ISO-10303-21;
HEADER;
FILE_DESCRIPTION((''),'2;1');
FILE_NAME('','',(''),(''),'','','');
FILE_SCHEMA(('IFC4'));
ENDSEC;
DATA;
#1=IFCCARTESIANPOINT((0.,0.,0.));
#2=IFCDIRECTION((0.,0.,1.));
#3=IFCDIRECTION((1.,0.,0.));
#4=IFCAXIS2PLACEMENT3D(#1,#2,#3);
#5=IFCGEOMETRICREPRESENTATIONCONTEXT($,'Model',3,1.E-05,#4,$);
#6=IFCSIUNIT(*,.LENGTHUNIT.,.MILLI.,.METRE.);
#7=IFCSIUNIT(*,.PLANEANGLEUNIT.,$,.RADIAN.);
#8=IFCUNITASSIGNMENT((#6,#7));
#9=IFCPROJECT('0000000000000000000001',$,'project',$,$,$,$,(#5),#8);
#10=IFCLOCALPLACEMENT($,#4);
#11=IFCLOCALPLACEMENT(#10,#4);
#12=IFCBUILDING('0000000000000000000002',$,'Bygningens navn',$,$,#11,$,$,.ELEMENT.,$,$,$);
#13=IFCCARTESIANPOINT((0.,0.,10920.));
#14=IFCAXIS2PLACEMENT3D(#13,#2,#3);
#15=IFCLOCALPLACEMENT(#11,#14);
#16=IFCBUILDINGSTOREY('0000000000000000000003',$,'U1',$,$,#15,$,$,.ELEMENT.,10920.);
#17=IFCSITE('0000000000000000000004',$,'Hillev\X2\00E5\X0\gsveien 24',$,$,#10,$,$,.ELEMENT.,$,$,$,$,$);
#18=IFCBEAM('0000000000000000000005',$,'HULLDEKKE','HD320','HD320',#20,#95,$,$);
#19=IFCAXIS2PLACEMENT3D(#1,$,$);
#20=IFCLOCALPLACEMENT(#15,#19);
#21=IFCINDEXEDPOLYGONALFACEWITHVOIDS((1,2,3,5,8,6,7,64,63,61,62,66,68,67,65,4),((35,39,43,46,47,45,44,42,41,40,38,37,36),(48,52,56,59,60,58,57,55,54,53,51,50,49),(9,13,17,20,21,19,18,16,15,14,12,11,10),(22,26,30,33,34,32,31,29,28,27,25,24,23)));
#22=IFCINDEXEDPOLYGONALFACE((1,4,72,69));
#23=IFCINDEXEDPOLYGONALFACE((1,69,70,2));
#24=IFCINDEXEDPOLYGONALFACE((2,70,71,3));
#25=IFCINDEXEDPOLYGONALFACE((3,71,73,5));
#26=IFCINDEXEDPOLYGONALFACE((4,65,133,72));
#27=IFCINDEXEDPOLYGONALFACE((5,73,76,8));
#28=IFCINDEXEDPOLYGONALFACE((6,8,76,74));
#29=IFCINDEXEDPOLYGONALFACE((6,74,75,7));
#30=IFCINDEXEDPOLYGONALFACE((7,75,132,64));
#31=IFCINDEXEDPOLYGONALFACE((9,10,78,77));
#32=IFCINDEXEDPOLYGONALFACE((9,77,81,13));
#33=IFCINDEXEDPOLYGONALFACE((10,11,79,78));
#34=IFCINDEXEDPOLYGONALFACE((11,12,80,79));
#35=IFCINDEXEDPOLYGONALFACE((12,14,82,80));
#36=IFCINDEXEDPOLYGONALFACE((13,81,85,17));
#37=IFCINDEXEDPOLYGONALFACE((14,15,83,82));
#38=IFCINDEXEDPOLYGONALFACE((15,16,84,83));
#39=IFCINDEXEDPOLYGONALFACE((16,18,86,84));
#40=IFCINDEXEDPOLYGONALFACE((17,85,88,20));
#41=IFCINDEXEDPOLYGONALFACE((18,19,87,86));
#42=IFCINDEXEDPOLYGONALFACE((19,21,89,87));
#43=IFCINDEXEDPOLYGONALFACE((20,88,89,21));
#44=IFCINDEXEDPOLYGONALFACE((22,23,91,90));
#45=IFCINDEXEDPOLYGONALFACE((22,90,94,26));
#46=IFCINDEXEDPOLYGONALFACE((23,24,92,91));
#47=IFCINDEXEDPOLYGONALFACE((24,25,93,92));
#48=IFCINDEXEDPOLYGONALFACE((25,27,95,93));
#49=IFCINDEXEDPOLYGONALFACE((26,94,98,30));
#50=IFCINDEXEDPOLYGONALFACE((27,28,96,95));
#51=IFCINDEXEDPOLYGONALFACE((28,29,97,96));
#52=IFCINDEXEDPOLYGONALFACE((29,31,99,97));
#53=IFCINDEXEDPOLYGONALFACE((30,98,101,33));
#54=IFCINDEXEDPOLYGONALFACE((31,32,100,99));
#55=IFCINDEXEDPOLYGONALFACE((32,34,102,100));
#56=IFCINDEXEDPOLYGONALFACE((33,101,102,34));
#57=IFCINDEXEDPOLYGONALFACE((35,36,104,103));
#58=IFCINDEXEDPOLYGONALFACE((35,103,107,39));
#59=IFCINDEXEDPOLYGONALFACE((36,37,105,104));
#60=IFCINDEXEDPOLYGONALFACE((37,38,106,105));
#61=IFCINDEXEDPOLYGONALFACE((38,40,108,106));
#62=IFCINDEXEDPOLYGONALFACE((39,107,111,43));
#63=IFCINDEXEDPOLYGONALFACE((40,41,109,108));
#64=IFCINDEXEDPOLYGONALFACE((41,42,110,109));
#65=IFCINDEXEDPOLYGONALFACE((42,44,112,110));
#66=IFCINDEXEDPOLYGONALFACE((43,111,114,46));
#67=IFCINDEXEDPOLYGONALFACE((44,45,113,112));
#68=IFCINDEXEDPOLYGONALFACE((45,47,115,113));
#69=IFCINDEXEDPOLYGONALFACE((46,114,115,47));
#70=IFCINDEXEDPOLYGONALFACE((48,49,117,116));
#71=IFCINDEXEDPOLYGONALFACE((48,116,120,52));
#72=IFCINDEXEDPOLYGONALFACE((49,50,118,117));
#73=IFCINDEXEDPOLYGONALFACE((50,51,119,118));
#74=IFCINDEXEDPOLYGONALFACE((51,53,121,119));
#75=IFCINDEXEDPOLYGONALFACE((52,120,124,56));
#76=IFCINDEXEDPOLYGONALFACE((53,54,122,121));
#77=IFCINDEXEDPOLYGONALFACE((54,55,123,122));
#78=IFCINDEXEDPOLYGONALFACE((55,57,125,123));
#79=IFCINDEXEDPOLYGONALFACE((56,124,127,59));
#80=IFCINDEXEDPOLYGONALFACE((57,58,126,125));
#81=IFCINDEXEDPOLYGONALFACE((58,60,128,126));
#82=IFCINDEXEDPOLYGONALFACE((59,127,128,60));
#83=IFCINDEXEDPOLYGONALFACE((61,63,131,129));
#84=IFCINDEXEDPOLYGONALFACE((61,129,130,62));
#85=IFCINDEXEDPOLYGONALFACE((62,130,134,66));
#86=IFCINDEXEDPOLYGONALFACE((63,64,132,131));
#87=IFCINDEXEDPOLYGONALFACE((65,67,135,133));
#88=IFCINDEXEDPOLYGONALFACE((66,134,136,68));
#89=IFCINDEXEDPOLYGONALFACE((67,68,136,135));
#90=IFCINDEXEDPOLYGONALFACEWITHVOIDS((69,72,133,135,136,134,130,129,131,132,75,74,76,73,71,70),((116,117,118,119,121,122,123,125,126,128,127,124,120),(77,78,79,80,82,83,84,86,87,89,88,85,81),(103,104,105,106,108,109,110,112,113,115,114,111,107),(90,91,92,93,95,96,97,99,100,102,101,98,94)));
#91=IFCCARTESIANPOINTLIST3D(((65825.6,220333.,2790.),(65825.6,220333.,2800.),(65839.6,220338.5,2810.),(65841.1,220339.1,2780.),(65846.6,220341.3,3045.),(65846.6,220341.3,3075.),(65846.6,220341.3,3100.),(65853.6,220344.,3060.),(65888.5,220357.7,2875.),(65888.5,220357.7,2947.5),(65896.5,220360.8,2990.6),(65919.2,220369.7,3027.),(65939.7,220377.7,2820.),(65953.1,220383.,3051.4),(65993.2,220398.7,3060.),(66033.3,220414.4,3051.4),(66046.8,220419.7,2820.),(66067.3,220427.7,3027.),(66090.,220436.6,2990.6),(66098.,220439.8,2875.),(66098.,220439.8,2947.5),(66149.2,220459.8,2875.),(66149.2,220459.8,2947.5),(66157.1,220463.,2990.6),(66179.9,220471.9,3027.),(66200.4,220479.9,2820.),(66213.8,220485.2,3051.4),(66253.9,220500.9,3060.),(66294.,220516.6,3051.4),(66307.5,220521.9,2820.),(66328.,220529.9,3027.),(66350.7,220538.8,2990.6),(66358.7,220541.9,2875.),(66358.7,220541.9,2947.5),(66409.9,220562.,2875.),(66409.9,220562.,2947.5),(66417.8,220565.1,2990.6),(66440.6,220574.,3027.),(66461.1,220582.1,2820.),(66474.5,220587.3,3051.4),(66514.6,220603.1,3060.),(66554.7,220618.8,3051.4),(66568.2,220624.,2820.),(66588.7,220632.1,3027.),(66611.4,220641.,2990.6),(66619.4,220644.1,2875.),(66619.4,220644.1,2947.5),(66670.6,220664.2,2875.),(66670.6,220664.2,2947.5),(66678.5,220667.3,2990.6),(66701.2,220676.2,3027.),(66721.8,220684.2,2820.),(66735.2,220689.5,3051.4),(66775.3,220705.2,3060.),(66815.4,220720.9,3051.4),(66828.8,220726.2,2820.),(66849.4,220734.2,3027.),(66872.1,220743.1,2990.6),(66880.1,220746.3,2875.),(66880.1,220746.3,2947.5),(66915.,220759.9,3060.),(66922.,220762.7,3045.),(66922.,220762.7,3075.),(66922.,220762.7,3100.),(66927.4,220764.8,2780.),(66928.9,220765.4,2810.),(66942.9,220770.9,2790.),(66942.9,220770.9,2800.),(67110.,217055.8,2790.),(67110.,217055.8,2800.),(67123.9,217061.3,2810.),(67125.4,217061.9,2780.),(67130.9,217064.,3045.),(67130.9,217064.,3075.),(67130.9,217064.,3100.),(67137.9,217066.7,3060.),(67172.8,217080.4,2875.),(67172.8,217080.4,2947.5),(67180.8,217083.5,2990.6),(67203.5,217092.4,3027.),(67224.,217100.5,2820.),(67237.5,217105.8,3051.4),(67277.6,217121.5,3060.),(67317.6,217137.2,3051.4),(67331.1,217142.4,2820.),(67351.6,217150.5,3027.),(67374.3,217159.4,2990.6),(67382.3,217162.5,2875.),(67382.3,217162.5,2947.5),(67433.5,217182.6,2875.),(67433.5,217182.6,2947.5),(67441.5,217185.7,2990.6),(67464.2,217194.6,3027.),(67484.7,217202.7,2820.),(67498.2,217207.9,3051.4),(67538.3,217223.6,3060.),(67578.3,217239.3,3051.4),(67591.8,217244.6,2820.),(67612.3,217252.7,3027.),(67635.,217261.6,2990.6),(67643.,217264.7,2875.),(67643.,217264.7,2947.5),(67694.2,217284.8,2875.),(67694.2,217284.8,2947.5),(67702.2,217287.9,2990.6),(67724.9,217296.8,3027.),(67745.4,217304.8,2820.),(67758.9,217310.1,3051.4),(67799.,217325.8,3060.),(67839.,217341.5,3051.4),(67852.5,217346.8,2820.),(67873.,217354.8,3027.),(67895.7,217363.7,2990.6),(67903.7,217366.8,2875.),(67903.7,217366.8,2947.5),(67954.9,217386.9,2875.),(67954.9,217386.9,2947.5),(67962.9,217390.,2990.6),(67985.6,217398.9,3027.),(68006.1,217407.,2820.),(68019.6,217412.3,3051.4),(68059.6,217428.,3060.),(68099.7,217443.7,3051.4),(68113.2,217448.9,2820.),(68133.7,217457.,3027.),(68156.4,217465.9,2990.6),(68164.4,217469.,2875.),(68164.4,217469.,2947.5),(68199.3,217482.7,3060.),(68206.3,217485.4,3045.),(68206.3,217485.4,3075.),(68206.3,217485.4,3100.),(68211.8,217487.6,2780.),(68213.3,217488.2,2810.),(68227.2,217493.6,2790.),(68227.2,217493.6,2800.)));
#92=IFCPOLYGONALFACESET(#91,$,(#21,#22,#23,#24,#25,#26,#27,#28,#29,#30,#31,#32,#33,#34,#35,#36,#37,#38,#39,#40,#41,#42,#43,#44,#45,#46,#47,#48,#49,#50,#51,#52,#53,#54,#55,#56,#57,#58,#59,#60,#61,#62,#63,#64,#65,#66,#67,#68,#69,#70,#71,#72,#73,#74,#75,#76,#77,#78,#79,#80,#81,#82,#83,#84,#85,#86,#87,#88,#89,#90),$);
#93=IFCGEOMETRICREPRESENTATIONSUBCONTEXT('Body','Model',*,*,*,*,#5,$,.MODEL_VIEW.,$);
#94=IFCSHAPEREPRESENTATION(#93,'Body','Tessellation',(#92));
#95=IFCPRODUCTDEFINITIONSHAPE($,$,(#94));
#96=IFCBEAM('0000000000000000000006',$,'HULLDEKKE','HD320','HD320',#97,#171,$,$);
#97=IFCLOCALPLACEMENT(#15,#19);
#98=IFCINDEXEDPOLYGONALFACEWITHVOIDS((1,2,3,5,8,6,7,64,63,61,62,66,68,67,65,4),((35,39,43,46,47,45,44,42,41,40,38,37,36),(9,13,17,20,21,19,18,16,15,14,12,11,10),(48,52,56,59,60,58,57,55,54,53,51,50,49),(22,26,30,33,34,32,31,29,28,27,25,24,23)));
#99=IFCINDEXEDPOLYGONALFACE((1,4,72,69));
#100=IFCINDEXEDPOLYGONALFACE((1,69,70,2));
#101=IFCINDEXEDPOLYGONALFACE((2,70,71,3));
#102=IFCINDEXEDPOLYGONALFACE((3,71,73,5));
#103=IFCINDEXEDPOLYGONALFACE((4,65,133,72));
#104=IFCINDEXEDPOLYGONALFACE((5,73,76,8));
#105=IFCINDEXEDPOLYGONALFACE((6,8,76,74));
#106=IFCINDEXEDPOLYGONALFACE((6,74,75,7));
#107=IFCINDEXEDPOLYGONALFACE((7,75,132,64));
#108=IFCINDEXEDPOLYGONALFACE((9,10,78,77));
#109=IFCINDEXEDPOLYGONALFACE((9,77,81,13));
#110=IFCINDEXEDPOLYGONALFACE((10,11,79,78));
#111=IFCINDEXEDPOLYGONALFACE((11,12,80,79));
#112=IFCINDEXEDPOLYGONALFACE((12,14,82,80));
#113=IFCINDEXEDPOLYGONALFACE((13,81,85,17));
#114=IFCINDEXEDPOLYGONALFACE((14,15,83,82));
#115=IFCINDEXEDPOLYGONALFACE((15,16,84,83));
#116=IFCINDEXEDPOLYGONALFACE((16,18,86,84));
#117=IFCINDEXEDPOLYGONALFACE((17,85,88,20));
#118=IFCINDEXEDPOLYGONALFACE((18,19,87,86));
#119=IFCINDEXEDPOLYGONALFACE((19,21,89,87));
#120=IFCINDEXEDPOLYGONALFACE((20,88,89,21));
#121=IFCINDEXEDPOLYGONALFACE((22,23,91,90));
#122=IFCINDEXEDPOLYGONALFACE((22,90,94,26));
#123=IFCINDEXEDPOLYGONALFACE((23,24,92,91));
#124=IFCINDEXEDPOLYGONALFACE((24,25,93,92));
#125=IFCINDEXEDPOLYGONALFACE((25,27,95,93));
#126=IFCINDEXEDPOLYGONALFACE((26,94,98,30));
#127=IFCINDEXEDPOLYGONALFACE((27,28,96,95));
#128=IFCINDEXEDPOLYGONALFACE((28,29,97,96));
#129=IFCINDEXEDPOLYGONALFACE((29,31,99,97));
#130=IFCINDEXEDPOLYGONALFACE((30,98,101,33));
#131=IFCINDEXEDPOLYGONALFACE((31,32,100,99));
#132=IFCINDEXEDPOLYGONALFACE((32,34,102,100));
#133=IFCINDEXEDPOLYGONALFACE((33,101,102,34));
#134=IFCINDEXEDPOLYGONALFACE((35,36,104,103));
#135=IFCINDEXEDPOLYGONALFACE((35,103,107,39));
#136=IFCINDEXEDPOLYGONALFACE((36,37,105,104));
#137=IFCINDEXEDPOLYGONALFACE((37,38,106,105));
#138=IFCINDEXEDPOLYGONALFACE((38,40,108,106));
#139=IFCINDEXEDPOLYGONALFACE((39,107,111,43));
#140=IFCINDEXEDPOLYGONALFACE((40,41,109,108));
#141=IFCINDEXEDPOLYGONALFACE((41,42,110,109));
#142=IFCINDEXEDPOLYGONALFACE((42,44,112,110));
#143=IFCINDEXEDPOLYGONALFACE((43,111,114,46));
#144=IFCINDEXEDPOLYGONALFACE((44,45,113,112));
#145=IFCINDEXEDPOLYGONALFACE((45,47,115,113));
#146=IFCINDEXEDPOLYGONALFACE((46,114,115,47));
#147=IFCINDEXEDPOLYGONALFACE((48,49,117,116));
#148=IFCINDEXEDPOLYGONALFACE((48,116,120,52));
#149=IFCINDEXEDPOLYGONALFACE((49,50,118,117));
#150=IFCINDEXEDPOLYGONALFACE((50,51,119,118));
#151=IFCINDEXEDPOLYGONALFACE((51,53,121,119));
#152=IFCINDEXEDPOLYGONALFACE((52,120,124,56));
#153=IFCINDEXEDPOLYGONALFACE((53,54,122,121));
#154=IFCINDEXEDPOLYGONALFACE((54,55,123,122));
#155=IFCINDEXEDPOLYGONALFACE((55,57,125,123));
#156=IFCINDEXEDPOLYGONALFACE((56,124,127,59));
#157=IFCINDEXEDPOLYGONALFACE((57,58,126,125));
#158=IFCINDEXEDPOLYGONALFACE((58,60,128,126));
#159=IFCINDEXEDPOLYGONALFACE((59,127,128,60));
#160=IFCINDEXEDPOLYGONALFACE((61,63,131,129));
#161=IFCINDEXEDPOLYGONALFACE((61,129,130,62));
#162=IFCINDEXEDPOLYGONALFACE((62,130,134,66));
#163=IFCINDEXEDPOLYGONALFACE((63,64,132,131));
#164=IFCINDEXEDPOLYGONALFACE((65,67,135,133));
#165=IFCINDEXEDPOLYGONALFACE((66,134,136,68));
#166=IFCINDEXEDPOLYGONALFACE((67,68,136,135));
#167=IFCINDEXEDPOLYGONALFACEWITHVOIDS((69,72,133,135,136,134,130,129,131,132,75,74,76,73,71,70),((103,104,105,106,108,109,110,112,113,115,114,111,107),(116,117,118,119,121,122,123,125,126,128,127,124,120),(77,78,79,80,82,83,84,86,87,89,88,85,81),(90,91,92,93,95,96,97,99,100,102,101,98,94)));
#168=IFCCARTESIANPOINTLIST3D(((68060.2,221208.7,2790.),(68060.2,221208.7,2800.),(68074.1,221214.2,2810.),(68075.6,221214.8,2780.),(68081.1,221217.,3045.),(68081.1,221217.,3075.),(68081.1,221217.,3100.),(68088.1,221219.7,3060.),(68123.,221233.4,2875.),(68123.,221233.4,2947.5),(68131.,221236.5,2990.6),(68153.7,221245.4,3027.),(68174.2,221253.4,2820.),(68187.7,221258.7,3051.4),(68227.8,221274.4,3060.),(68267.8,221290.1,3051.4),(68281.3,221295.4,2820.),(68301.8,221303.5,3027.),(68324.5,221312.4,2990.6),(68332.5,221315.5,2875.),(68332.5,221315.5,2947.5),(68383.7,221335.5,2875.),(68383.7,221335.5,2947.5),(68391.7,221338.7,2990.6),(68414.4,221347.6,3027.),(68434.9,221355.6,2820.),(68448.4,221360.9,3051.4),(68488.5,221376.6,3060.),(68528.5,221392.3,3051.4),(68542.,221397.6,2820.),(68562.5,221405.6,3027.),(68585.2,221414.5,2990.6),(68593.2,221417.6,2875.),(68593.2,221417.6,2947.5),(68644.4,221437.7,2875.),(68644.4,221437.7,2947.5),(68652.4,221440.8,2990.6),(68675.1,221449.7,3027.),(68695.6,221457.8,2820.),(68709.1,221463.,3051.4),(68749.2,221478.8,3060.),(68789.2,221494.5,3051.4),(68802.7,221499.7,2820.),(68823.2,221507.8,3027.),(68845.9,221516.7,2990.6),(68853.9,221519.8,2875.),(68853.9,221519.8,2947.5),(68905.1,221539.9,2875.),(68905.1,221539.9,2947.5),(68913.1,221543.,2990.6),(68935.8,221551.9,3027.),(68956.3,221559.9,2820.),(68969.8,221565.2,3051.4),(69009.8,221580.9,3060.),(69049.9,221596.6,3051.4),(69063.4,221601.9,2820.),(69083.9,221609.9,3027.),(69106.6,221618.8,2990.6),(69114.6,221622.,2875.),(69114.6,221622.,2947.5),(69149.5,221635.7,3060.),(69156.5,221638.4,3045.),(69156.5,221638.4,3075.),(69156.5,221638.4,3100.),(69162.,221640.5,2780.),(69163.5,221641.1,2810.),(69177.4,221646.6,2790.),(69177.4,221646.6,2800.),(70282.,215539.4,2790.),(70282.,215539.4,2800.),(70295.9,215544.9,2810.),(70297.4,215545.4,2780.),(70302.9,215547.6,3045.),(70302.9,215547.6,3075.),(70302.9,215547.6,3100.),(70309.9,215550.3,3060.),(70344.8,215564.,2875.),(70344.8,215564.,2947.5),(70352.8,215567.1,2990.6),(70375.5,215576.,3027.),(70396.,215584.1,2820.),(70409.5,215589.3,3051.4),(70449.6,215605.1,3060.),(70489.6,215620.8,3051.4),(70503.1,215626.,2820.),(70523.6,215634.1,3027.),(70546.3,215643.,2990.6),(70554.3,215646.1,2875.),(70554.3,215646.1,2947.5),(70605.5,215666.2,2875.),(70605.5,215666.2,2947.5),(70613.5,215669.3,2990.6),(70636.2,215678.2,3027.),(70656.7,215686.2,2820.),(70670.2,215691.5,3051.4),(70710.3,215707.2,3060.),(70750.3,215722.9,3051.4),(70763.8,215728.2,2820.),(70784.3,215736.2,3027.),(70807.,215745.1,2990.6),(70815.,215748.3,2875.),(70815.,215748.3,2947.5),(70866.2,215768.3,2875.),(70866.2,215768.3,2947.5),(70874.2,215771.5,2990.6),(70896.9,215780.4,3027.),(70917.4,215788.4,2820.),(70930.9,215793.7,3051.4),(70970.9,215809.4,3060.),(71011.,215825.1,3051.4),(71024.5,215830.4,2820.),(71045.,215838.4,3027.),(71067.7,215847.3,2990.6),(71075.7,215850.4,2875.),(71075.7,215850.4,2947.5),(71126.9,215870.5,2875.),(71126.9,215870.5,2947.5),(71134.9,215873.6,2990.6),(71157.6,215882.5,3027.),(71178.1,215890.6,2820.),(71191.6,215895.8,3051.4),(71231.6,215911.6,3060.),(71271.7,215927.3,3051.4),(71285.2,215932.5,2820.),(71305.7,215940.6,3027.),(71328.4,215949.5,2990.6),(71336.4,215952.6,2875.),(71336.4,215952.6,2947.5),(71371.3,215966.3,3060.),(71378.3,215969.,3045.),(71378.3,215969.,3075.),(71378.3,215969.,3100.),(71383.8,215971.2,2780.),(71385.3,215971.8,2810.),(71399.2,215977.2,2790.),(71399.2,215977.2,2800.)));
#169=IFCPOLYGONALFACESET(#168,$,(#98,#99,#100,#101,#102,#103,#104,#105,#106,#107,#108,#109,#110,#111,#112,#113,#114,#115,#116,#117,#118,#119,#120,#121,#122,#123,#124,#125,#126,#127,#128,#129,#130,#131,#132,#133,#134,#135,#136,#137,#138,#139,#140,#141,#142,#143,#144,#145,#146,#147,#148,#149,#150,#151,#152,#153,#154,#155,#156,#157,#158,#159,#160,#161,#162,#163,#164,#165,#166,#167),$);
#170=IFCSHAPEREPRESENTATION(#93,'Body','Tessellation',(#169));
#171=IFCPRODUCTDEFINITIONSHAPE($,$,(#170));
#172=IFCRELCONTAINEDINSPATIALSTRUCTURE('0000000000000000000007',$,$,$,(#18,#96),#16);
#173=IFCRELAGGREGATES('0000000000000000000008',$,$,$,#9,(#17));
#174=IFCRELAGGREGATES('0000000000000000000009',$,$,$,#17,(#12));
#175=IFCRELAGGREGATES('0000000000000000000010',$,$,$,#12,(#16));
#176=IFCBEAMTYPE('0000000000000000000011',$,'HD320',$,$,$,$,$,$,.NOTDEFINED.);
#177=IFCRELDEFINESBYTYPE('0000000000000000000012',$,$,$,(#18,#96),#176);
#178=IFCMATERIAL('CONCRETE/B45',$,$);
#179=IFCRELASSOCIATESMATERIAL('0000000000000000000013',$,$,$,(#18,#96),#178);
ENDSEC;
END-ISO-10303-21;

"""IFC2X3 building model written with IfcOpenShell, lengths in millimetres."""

from ifc_helpers import new_model, si_unit, frame, origin_with_axes, place, context, subcontext, project, spatial, polyline, outline, extrude, material, type_object, element, save


model = new_model("IFC2X3")

# Units and contexts
model_context = context("Model", 3, precision=1e-05, world=origin_with_axes())
body_context = subcontext(model_context, "Body", "Model", "MODEL_VIEW")
ifc_project = project(units=[si_unit("LENGTHUNIT", "METRE", prefix="MILLI"), si_unit("PLANEANGLEUNIT", "RADIAN")], contexts=[model_context])

# Site, building, storey
site_placement = place(None, origin_with_axes())
site = spatial("IfcSite", under=ifc_project, at=site_placement, Name="Hillevågsveien 24", CompositionType="ELEMENT")
building_placement = place(site_placement, origin_with_axes())
building = spatial("IfcBuilding", under=site, at=building_placement, Name="Bygningens navn", CompositionType="ELEMENT")
storey_placement = place(building_placement, frame((0.0, 0.0, 10920.0), z_axis=(0.0, 0.0, 1.0), x_axis=(1.0, 0.0, 0.0)))
storey = spatial("IfcBuildingStorey", under=building, at=storey_placement, Name="U1", CompositionType="ELEMENT", Elevation=10920.0)

# Beams
ifc_material_1 = material(Name="CONCRETE/B45")
beam_type_1 = type_object("IfcBeamType", Name="HD320", PredefinedType="NOTDEFINED")
beam_1_placement = place(storey_placement, frame((67668.6, 217274.7, 2940.0), z_axis=(0.0, 0.0, 1.0), x_axis=(-0.364876, 0.931056, 0.0)))
element("IfcBeam", 1, at=beam_1_placement, inside=storey, type_object=beam_type_1, material=ifc_material_1, Name="HULLDEKKE", Description="HD320", ObjectType="HD320", context=body_context, shape_type="SweptSolid", body=[
    extrude(outline(polyline([(577.5, 105.0), (585.0, -130.0), (600.0, -140.0), (600.0, -150.0), (583.4, -160.0), (-583.4, -160.0), (-600.0, -150.0), (-600.0, -140.0), (-585.0, -130.0), (-577.5, 105.0), (-570.0, 120.0), (-577.5, 135.0), (-577.5, 160.0), (577.5, 160.0), (577.5, 135.0), (570.0, 120.0), (577.5, 105.0)]), holes=[polyline([(477.5, -120.0), (532.5, -65.0), (532.5, 7.5), (523.9, 50.6), (499.5, 87.0), (463.1, 111.4), (420.0, 120.0), (376.9, 111.4), (340.5, 87.0), (316.1, 50.6), (307.5, 7.5), (307.5, -65.0), (362.5, -120.0), (477.5, -120.0)]), polyline([(197.5, -120.0), (252.5, -65.0), (252.5, 7.5), (243.9, 50.6), (219.5, 87.0), (183.1, 111.4), (140.0, 120.0), (96.9, 111.4), (60.5, 87.0), (36.1, 50.6), (27.5, 7.5), (27.5, -65.0), (82.5, -120.0), (197.5, -120.0)]), polyline([(-82.5, -120.0), (-27.5, -65.0), (-27.5, 7.5), (-36.1, 50.6), (-60.5, 87.0), (-96.9, 111.4), (-140.0, 120.0), (-183.1, 111.4), (-219.5, 87.0), (-243.9, 50.6), (-252.5, 7.5), (-252.5, -65.0), (-197.5, -120.0), (-82.5, -120.0)]), polyline([(-362.5, -120.0), (-307.5, -65.0), (-307.5, 7.5), (-316.1, 50.6), (-340.5, 87.0), (-376.9, 111.4), (-420.0, 120.0), (-463.1, 111.4), (-499.5, 87.0), (-523.9, 50.6), (-532.5, 7.5), (-532.5, -65.0), (-477.5, -120.0), (-362.5, -120.0)])]), frame((3519.9, 0.0, 0.0), z_axis=(-1.0, 0.0, 0.0), x_axis=(0.0, -1.0, 0.0)), (0.0, 0.0, 1.0), 3519.9),
])
beam_2_placement = place(storey_placement, frame((70840.6, 215758.3, 2940.0), z_axis=(0.0, 0.0, 1.0), x_axis=(-0.364876, 0.931056, 0.0)))
element("IfcBeam", 2, at=beam_2_placement, inside=storey, type_object=beam_type_1, material=ifc_material_1, Name="HULLDEKKE", Description="HD320", ObjectType="HD320", context=body_context, shape_type="SweptSolid", body=[
    extrude(outline(polyline([(577.5, 105.0), (585.0, -130.0), (600.0, -140.0), (600.0, -150.0), (583.4, -160.0), (-583.4, -160.0), (-600.0, -150.0), (-600.0, -140.0), (-585.0, -130.0), (-577.5, 105.0), (-570.0, 120.0), (-577.5, 135.0), (-577.5, 160.0), (577.5, 160.0), (577.5, 135.0), (570.0, 120.0), (577.5, 105.0)]), holes=[polyline([(477.5, -120.0), (532.5, -65.0), (532.5, 7.5), (523.9, 50.6), (499.5, 87.0), (463.1, 111.4), (420.0, 120.0), (376.9, 111.4), (340.5, 87.0), (316.1, 50.6), (307.5, 7.5), (307.5, -65.0), (362.5, -120.0), (477.5, -120.0)]), polyline([(197.5, -120.0), (252.5, -65.0), (252.5, 7.5), (243.9, 50.6), (219.5, 87.0), (183.1, 111.4), (140.0, 120.0), (96.9, 111.4), (60.5, 87.0), (36.1, 50.6), (27.5, 7.5), (27.5, -65.0), (82.5, -120.0), (197.5, -120.0)]), polyline([(-82.5, -120.0), (-27.5, -65.0), (-27.5, 7.5), (-36.1, 50.6), (-60.5, 87.0), (-96.9, 111.4), (-140.0, 120.0), (-183.1, 111.4), (-219.5, 87.0), (-243.9, 50.6), (-252.5, 7.5), (-252.5, -65.0), (-197.5, -120.0), (-82.5, -120.0)]), polyline([(-362.5, -120.0), (-307.5, -65.0), (-307.5, 7.5), (-316.1, 50.6), (-340.5, 87.0), (-376.9, 111.4), (-420.0, 120.0), (-463.1, 111.4), (-499.5, 87.0), (-523.9, 50.6), (-532.5, 7.5), (-532.5, -65.0), (-477.5, -120.0), (-362.5, -120.0)])]), frame((6089.2, 0.0, 0.0), z_axis=(-1.0, 0.0, 0.0), x_axis=(0.0, -1.0, 0.0)), (0.0, 0.0, 1.0), 6089.2),
])

save(model, "model.ifc")
